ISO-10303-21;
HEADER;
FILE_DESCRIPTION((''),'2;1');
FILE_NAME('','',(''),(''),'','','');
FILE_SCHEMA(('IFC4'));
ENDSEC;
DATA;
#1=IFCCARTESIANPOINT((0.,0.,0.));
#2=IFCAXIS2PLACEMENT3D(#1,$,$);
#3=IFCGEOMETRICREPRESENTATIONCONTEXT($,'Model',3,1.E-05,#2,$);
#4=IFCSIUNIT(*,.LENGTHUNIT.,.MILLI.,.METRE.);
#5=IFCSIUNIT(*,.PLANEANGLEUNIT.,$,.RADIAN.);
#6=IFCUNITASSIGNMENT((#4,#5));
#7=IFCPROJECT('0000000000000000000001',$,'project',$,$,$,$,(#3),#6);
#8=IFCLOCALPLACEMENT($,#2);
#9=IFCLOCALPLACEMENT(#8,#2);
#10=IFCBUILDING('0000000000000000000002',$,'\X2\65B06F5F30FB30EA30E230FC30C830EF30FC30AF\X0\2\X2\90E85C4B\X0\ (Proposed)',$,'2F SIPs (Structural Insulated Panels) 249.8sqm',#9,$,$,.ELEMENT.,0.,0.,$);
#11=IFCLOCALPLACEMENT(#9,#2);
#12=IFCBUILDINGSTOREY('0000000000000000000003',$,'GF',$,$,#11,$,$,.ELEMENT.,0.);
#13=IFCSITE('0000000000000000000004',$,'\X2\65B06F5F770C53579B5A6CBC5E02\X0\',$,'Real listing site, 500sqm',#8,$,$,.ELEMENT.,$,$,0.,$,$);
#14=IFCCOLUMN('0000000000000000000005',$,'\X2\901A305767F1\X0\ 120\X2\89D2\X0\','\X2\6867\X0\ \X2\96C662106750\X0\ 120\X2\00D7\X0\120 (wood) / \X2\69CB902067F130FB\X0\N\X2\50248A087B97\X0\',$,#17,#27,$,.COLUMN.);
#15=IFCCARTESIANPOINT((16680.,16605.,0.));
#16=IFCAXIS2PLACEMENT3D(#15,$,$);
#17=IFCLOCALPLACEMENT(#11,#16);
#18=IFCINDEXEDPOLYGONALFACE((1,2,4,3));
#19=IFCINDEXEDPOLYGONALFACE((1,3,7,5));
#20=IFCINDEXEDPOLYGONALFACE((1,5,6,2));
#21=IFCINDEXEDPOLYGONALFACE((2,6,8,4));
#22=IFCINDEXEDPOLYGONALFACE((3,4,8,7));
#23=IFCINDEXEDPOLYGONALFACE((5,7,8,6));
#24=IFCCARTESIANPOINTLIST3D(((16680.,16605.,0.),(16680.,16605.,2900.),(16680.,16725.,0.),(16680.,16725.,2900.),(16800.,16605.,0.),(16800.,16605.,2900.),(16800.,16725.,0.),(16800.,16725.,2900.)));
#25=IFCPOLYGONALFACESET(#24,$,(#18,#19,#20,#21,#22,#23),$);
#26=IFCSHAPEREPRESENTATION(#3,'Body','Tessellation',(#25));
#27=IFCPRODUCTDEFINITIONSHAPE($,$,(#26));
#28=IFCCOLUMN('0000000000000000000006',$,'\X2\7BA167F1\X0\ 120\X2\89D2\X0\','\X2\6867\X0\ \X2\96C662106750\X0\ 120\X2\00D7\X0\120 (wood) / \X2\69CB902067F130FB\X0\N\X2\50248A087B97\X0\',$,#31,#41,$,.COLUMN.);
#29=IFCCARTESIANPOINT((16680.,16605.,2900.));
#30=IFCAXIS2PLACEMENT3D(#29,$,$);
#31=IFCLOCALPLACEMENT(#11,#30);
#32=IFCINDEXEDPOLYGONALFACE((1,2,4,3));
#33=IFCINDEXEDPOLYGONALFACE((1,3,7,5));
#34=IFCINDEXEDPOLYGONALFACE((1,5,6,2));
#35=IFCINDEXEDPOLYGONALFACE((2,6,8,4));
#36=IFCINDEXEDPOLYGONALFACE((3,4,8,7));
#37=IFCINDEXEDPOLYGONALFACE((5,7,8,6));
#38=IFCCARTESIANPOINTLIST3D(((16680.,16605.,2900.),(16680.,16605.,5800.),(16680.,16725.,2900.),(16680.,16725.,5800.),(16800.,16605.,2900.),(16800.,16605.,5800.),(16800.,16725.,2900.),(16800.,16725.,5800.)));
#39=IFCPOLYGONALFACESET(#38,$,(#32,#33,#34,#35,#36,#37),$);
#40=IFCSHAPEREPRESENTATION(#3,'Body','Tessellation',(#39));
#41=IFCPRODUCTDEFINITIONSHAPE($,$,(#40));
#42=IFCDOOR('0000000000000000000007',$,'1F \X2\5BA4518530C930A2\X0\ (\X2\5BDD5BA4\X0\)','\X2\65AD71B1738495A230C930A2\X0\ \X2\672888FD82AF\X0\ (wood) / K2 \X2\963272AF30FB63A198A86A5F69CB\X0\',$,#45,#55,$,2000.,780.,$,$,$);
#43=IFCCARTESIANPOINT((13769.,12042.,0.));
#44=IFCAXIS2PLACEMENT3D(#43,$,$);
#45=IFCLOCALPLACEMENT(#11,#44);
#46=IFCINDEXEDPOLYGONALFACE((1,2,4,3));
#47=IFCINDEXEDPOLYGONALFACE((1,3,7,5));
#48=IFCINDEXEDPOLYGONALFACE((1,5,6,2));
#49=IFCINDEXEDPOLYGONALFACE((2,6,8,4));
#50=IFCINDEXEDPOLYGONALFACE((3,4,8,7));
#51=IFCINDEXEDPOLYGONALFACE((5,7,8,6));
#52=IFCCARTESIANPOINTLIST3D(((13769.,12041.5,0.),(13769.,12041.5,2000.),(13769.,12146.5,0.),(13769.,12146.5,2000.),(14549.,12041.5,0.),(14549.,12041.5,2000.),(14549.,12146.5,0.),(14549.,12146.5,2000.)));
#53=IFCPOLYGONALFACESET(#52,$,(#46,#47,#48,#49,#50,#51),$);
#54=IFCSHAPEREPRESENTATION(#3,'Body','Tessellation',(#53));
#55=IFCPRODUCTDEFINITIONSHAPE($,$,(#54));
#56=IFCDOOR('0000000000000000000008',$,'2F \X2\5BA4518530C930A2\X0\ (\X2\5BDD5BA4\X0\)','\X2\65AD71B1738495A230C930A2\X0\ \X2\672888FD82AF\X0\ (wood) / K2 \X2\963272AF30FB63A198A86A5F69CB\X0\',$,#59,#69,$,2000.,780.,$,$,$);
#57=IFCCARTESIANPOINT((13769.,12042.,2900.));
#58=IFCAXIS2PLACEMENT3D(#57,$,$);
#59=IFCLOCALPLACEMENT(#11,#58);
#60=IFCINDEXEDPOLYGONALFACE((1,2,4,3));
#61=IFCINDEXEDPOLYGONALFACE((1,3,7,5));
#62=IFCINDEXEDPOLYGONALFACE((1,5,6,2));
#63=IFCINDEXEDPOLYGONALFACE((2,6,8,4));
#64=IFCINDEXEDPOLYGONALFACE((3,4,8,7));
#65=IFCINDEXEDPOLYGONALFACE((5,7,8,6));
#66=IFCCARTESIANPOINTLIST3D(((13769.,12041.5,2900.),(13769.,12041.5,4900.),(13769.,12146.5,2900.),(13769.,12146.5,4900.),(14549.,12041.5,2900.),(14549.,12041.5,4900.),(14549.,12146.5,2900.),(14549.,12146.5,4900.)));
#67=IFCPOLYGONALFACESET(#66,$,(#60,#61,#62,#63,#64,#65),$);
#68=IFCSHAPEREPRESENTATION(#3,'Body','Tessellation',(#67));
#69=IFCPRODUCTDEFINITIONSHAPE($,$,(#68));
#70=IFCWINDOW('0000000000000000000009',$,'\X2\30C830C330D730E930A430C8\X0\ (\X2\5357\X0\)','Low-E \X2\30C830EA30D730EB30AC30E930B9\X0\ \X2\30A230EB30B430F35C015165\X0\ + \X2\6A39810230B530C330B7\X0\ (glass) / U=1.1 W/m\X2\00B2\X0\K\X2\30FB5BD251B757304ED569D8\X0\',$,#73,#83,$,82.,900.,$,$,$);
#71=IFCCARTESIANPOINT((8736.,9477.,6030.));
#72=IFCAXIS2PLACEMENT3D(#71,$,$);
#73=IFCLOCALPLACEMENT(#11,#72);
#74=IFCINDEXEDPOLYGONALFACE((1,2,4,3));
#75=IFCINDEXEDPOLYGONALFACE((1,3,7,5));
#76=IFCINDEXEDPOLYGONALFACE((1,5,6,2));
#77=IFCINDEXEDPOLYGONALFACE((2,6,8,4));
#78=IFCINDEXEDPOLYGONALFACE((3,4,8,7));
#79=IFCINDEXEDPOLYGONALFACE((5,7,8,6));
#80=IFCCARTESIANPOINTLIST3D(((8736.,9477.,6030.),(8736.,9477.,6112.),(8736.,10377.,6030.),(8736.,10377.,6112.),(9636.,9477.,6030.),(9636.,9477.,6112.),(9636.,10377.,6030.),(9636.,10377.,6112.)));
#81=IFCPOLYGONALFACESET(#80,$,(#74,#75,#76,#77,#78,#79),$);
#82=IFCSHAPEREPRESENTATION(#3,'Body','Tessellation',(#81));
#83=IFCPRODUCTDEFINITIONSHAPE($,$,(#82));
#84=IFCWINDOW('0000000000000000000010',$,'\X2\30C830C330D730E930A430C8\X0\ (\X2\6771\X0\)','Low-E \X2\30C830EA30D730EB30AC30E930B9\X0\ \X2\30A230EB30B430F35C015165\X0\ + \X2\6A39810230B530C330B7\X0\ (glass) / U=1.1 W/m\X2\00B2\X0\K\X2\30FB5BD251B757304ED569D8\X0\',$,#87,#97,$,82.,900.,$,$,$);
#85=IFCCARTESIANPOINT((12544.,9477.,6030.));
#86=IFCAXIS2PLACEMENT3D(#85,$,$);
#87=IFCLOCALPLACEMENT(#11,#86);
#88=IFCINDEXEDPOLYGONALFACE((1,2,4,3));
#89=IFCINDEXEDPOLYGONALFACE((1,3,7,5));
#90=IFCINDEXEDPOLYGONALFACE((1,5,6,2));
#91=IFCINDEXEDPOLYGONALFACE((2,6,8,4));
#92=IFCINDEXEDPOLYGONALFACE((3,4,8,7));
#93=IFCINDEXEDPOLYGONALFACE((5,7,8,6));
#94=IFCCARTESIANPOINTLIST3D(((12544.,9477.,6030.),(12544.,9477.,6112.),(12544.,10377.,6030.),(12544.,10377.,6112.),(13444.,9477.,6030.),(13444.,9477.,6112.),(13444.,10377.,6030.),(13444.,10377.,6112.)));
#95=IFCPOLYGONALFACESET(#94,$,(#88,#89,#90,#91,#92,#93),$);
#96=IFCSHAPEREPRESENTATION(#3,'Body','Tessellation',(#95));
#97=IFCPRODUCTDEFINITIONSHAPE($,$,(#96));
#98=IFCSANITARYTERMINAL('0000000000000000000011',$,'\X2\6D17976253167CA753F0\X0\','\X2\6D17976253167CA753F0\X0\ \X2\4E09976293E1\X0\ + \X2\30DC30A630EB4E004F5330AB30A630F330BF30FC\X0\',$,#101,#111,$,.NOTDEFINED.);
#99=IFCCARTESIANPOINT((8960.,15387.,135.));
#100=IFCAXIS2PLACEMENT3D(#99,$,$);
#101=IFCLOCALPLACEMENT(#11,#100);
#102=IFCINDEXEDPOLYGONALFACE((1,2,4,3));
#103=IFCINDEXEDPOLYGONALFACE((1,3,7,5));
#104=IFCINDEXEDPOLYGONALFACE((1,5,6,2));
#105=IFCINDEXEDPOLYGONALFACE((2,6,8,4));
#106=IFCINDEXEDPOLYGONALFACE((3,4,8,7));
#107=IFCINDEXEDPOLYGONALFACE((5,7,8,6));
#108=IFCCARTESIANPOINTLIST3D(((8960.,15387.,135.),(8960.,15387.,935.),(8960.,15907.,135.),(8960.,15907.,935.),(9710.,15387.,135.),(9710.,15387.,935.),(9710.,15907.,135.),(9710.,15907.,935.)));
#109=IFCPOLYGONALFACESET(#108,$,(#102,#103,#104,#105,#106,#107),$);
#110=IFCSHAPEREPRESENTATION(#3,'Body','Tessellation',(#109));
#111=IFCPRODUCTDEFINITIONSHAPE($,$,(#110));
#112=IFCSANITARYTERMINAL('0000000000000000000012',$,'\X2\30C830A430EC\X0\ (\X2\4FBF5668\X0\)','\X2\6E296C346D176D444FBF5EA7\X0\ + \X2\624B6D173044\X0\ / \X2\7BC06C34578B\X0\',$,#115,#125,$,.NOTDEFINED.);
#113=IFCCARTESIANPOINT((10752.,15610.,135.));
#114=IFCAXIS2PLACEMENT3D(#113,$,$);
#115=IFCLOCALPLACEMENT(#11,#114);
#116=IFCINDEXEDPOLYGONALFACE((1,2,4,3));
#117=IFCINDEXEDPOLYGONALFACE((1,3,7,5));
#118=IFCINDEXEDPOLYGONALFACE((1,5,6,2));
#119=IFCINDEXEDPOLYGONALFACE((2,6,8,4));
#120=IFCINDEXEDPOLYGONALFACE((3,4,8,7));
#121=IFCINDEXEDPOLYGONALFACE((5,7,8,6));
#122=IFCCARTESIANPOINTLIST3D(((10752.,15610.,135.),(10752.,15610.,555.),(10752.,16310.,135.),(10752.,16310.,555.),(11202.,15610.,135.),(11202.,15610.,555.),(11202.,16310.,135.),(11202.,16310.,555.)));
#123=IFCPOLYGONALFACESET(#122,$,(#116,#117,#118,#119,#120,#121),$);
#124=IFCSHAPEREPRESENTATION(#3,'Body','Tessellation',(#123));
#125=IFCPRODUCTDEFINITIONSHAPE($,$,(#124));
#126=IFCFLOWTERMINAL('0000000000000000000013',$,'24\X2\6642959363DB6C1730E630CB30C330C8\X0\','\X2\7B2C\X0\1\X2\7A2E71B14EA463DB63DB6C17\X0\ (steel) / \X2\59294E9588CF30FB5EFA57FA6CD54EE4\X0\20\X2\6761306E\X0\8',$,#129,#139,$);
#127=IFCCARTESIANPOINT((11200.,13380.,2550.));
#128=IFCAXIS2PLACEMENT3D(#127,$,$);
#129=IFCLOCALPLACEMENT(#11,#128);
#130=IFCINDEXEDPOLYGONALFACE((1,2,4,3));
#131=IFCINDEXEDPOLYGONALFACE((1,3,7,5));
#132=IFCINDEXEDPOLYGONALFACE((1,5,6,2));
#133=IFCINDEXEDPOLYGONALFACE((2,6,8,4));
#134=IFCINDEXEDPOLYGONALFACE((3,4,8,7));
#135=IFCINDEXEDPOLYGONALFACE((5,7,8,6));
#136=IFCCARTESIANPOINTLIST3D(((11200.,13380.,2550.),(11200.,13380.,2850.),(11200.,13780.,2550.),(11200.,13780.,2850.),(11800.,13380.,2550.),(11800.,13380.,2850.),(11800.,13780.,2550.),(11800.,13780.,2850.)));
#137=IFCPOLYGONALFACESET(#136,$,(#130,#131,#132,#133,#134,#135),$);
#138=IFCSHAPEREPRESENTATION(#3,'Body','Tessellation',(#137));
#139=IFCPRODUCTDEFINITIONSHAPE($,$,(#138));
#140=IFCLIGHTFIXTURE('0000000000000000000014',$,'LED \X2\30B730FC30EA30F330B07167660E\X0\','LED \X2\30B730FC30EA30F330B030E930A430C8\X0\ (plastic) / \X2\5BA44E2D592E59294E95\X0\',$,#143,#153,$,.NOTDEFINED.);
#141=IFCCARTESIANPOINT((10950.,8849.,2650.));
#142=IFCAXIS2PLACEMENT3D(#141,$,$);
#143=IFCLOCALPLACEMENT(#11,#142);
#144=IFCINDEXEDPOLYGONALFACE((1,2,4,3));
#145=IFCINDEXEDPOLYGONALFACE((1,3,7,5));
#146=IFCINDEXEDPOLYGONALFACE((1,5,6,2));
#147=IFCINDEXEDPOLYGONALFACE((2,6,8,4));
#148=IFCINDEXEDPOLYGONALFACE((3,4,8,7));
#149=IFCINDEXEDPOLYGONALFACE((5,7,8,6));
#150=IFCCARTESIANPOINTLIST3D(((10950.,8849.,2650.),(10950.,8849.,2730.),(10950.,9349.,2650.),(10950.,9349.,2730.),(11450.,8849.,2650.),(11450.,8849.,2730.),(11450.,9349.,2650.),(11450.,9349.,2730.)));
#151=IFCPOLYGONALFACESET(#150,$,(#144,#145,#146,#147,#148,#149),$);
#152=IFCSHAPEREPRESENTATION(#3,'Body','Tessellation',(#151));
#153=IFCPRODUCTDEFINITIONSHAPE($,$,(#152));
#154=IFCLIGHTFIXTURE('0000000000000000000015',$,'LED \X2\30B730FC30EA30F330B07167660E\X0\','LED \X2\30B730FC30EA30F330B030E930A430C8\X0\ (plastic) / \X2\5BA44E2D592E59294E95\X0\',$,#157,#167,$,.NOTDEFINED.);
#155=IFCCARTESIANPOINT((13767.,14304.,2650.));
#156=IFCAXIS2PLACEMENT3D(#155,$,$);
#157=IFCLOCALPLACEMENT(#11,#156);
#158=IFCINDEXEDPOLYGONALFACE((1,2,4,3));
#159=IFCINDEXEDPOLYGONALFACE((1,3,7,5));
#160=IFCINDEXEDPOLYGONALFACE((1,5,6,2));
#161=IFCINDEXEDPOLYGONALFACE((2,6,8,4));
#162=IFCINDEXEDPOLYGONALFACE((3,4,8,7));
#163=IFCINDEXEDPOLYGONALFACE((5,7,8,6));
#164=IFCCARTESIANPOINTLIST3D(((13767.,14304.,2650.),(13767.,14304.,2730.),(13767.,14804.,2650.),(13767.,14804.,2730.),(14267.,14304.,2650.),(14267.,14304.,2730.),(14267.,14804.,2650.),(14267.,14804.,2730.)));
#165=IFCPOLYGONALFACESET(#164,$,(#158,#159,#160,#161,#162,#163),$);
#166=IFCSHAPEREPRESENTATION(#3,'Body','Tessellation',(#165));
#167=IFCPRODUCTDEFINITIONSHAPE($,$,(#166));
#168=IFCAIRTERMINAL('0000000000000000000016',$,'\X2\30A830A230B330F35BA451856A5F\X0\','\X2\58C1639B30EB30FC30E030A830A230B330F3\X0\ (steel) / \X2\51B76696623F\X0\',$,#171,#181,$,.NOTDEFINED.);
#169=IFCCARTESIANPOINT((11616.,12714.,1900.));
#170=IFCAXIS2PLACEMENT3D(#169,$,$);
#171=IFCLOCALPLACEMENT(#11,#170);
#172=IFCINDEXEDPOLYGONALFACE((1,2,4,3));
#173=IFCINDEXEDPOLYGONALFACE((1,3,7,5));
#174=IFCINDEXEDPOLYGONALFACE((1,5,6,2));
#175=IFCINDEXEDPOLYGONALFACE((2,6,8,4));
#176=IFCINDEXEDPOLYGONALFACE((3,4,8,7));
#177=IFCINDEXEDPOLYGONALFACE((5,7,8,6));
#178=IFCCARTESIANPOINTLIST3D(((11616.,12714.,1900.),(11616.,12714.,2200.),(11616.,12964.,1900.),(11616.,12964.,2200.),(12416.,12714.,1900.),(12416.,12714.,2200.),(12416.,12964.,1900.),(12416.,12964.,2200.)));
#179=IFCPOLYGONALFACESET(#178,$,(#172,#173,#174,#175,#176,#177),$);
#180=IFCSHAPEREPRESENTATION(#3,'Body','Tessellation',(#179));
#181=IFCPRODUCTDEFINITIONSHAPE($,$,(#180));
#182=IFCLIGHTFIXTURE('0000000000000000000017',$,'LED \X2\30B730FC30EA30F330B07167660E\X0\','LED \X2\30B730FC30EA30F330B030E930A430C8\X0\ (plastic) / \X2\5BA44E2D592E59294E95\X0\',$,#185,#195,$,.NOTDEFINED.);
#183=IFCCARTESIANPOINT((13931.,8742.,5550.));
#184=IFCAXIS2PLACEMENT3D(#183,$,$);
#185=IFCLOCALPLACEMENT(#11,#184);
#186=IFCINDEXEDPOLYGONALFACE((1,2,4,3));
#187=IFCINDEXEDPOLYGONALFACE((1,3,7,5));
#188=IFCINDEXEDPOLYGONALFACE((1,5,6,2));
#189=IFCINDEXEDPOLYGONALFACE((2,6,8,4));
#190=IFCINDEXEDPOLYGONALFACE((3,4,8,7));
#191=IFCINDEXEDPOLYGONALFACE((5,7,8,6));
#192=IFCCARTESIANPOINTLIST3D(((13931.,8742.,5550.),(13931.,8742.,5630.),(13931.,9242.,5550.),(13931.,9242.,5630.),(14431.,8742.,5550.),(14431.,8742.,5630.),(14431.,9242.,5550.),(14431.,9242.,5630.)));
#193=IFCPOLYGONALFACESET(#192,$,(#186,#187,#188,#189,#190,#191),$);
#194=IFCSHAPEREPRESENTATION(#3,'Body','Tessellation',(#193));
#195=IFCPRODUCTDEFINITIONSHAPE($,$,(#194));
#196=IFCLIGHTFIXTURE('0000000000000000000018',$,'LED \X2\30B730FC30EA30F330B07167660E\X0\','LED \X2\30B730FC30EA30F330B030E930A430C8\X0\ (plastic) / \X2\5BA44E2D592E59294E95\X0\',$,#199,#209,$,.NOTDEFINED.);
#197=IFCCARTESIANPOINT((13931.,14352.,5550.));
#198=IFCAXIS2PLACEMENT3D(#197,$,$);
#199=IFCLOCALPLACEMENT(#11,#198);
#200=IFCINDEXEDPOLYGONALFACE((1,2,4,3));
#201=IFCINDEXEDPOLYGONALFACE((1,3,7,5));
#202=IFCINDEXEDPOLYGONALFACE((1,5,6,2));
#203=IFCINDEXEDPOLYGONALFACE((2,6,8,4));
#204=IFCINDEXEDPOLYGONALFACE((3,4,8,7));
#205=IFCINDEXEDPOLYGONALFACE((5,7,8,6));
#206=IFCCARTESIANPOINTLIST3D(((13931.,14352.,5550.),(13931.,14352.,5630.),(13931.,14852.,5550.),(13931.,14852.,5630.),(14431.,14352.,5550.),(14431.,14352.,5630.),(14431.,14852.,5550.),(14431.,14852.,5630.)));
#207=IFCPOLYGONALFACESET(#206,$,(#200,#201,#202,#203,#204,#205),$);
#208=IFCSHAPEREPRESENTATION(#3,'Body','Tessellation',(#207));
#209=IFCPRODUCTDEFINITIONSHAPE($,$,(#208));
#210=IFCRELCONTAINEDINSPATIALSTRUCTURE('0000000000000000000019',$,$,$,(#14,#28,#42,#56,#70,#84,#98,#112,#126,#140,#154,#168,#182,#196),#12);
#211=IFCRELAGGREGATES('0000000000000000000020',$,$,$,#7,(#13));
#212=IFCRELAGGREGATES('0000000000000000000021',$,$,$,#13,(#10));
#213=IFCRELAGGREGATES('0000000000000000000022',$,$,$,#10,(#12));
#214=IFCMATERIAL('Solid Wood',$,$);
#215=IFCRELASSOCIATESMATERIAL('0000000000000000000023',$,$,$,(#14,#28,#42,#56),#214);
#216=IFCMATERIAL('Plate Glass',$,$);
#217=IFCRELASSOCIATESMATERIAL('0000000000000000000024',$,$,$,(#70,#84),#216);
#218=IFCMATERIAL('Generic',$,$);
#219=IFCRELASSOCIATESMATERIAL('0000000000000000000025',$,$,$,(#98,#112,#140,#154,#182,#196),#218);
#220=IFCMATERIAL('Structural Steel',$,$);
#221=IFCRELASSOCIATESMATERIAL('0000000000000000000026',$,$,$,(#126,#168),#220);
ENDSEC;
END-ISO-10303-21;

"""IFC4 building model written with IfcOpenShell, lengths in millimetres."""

from ifc_helpers import new_model, si_unit, frame, frame_2d, origin, place, context, project, spatial, rectangle, extrude, material, element, save


model = new_model("IFC4")

# Units and contexts
model_context = context("Model", 3, precision=1e-05, world=origin())
ifc_project = project(units=[si_unit("LENGTHUNIT", "METRE", prefix="MILLI"), si_unit("PLANEANGLEUNIT", "RADIAN")], contexts=[model_context])

# Site, building, storey
site_placement = place(None, origin())
site = spatial("IfcSite", under=ifc_project, at=site_placement, Name="新潟県南魚沼市", ObjectType="Real listing site, 500sqm", CompositionType="ELEMENT", RefElevation=0.0)
building_placement = place(site_placement, origin())
building = spatial("IfcBuilding", under=site, at=building_placement, Name="新潟・リモートワーク2部屋 (Proposed)", ObjectType="2F SIPs (Structural Insulated Panels) 249.8sqm", CompositionType="ELEMENT", ElevationOfRefHeight=0.0, ElevationOfTerrain=0.0)
storey_placement = place(building_placement, origin())
storey = spatial("IfcBuildingStorey", under=building, at=storey_placement, Name="GF", CompositionType="ELEMENT", Elevation=0.0)

# Columns
ifc_material_1 = material(Name="Solid Wood")
column_1_placement = place(storey_placement, frame((16680.0, 16605.0, 0.0)))
element("IfcColumn", 1, at=column_1_placement, inside=storey, material=ifc_material_1, Name="通し柱 120角", Description="桧 集成材 120×120 (wood) / 構造柱・N値計算", PredefinedType="COLUMN", context=model_context, shape_type="SweptSolid", body=[
    extrude(rectangle(XDim=120.0, YDim=120.0, at=frame_2d((60.0, 60.0))), frame((16680.0, 16605.0, 0.0)), (0.0, 0.0, 1.0), 2900.0),
])
column_2_placement = place(storey_placement, frame((16680.0, 16605.0, 2900.0)))
element("IfcColumn", 2, at=column_2_placement, inside=storey, material=ifc_material_1, Name="管柱 120角", Description="桧 集成材 120×120 (wood) / 構造柱・N値計算", PredefinedType="COLUMN", context=model_context, shape_type="SweptSolid", body=[
    extrude(rectangle(XDim=120.0, YDim=120.0, at=frame_2d((60.0, 60.0))), frame((16680.0, 16605.0, 2900.0)), (0.0, 0.0, 1.0), 2900.0),
])

# Door
door_1_placement = place(storey_placement, frame((13769.0, 12042.0, 0.0)))
element("IfcDoor", 3, at=door_1_placement, inside=storey, material=ifc_material_1, Name="1F 室内ドア (寝室)", Description="断熱玄関ドア 木製芯 (wood) / K2 防犯・採風機構", OverallHeight=2000.0, OverallWidth=780.0, context=model_context, shape_type="SweptSolid", body=[
    extrude(rectangle(XDim=780.0, YDim=105.0, at=frame_2d((390.0, 52.0))), frame((13769.0, 12042.0, 0.0)), (0.0, 0.0, 1.0), 2000.0),
])

# Door
door_2_placement = place(storey_placement, frame((13769.0, 12042.0, 2900.0)))
element("IfcDoor", 4, at=door_2_placement, inside=storey, material=ifc_material_1, Name="2F 室内ドア (寝室)", Description="断熱玄関ドア 木製芯 (wood) / K2 防犯・採風機構", OverallHeight=2000.0, OverallWidth=780.0, context=model_context, shape_type="SweptSolid", body=[
    extrude(rectangle(XDim=780.0, YDim=105.0, at=frame_2d((390.0, 52.0))), frame((13769.0, 12042.0, 2900.0)), (0.0, 0.0, 1.0), 2000.0),
])

# Windows
ifc_material_2 = material(Name="Plate Glass")
window_1_placement = place(storey_placement, frame((8736.0, 9477.0, 6030.0)))
element("IfcWindow", 5, at=window_1_placement, inside=storey, material=ifc_material_2, Name="トップライト (南)", Description="Low-E トリプルガラス アルゴン封入 + 樹脂サッシ (glass) / U=1.1 W/m²K・寒冷地仕様", OverallHeight=82.0, OverallWidth=900.0, context=model_context, shape_type="SweptSolid", body=[
    extrude(rectangle(XDim=900.0, YDim=900.0, at=frame_2d((450.0, 450.0))), frame((8736.0, 9477.0, 6030.0)), (0.0, 0.0, 1.0), 82.0),
])
window_2_placement = place(storey_placement, frame((12544.0, 9477.0, 6030.0)))
element("IfcWindow", 6, at=window_2_placement, inside=storey, material=ifc_material_2, Name="トップライト (東)", Description="Low-E トリプルガラス アルゴン封入 + 樹脂サッシ (glass) / U=1.1 W/m²K・寒冷地仕様", OverallHeight=82.0, OverallWidth=900.0, context=model_context, shape_type="SweptSolid", body=[
    extrude(rectangle(XDim=900.0, YDim=900.0, at=frame_2d((450.0, 450.0))), frame((12544.0, 9477.0, 6030.0)), (0.0, 0.0, 1.0), 82.0),
])

# Sanitary terminals
ifc_material_3 = material(Name="Generic")
sanitary_terminal_1_placement = place(storey_placement, frame((8960.0, 15387.0, 135.0)))
element("IfcSanitaryTerminal", 7, at=sanitary_terminal_1_placement, inside=storey, material=ifc_material_3, Name="洗面化粧台", Description="洗面化粧台 三面鏡 + ボウル一体カウンター", PredefinedType="NOTDEFINED", context=model_context, shape_type="SweptSolid", body=[
    extrude(rectangle(XDim=750.0, YDim=520.0, at=frame_2d((375.0, 260.0))), frame((8960.0, 15387.0, 135.0)), (0.0, 0.0, 1.0), 800.0),
])
sanitary_terminal_2_placement = place(storey_placement, frame((10752.0, 15610.0, 135.0)))
element("IfcSanitaryTerminal", 8, at=sanitary_terminal_2_placement, inside=storey, material=ifc_material_3, Name="トイレ (便器)", Description="温水洗浄便座 + 手洗い / 節水型", PredefinedType="NOTDEFINED", context=model_context, shape_type="SweptSolid", body=[
    extrude(rectangle(XDim=450.0, YDim=700.0, at=frame_2d((225.0, 350.0))), frame((10752.0, 15610.0, 135.0)), (0.0, 0.0, 1.0), 420.0),
])

# Flow terminal
ifc_material_4 = material(Name="Structural Steel")
flow_terminal_placement = place(storey_placement, frame((11200.0, 13380.0, 2550.0)))
element("IfcFlowTerminal", 9, at=flow_terminal_placement, inside=storey, material=ifc_material_4, Name="24時間換気ユニット", Description="第1種熱交換換気 (steel) / 天井裏・建基法令20条の8", context=model_context, shape_type="SweptSolid", body=[
    extrude(rectangle(XDim=600.0, YDim=400.0, at=frame_2d((300.0, 200.0))), frame((11200.0, 13380.0, 2550.0)), (0.0, 0.0, 1.0), 300.0),
])

# Light fixtures
light_fixture_1_placement = place(storey_placement, frame((10950.0, 8849.0, 2650.0)))
element("IfcLightFixture", 10, at=light_fixture_1_placement, inside=storey, material=ifc_material_3, Name="LED シーリング照明", Description="LED シーリングライト (plastic) / 室中央天井", PredefinedType="NOTDEFINED", context=model_context, shape_type="SweptSolid", body=[
    extrude(rectangle(XDim=500.0, YDim=500.0, at=frame_2d((250.0, 250.0))), frame((10950.0, 8849.0, 2650.0)), (0.0, 0.0, 1.0), 80.0),
])
light_fixture_2_placement = place(storey_placement, frame((13767.0, 14304.0, 2650.0)))
element("IfcLightFixture", 11, at=light_fixture_2_placement, inside=storey, material=ifc_material_3, Name="LED シーリング照明", Description="LED シーリングライト (plastic) / 室中央天井", PredefinedType="NOTDEFINED", context=model_context, shape_type="SweptSolid", body=[
    extrude(rectangle(XDim=500.0, YDim=500.0, at=frame_2d((250.0, 250.0))), frame((13767.0, 14304.0, 2650.0)), (0.0, 0.0, 1.0), 80.0),
])

# Air terminal
air_terminal_placement = place(storey_placement, frame((11616.0, 12714.0, 1900.0)))
element("IfcAirTerminal", 12, at=air_terminal_placement, inside=storey, material=ifc_material_4, Name="エアコン室内機", Description="壁掛ルームエアコン (steel) / 冷暖房", PredefinedType="NOTDEFINED", context=model_context, shape_type="SweptSolid", body=[
    extrude(rectangle(XDim=800.0, YDim=250.0, at=frame_2d((400.0, 125.0))), frame((11616.0, 12714.0, 1900.0)), (0.0, 0.0, 1.0), 300.0),
])

# Light fixtures
light_fixture_3_placement = place(storey_placement, frame((13931.0, 8742.0, 5550.0)))
element("IfcLightFixture", 13, at=light_fixture_3_placement, inside=storey, material=ifc_material_3, Name="LED シーリング照明", Description="LED シーリングライト (plastic) / 室中央天井", PredefinedType="NOTDEFINED", context=model_context, shape_type="SweptSolid", body=[
    extrude(rectangle(XDim=500.0, YDim=500.0, at=frame_2d((250.0, 250.0))), frame((13931.0, 8742.0, 5550.0)), (0.0, 0.0, 1.0), 80.0),
])
light_fixture_4_placement = place(storey_placement, frame((13931.0, 14352.0, 5550.0)))
element("IfcLightFixture", 14, at=light_fixture_4_placement, inside=storey, material=ifc_material_3, Name="LED シーリング照明", Description="LED シーリングライト (plastic) / 室中央天井", PredefinedType="NOTDEFINED", context=model_context, shape_type="SweptSolid", body=[
    extrude(rectangle(XDim=500.0, YDim=500.0, at=frame_2d((250.0, 250.0))), frame((13931.0, 14352.0, 5550.0)), (0.0, 0.0, 1.0), 80.0),
])

save(model, "model.ifc")
